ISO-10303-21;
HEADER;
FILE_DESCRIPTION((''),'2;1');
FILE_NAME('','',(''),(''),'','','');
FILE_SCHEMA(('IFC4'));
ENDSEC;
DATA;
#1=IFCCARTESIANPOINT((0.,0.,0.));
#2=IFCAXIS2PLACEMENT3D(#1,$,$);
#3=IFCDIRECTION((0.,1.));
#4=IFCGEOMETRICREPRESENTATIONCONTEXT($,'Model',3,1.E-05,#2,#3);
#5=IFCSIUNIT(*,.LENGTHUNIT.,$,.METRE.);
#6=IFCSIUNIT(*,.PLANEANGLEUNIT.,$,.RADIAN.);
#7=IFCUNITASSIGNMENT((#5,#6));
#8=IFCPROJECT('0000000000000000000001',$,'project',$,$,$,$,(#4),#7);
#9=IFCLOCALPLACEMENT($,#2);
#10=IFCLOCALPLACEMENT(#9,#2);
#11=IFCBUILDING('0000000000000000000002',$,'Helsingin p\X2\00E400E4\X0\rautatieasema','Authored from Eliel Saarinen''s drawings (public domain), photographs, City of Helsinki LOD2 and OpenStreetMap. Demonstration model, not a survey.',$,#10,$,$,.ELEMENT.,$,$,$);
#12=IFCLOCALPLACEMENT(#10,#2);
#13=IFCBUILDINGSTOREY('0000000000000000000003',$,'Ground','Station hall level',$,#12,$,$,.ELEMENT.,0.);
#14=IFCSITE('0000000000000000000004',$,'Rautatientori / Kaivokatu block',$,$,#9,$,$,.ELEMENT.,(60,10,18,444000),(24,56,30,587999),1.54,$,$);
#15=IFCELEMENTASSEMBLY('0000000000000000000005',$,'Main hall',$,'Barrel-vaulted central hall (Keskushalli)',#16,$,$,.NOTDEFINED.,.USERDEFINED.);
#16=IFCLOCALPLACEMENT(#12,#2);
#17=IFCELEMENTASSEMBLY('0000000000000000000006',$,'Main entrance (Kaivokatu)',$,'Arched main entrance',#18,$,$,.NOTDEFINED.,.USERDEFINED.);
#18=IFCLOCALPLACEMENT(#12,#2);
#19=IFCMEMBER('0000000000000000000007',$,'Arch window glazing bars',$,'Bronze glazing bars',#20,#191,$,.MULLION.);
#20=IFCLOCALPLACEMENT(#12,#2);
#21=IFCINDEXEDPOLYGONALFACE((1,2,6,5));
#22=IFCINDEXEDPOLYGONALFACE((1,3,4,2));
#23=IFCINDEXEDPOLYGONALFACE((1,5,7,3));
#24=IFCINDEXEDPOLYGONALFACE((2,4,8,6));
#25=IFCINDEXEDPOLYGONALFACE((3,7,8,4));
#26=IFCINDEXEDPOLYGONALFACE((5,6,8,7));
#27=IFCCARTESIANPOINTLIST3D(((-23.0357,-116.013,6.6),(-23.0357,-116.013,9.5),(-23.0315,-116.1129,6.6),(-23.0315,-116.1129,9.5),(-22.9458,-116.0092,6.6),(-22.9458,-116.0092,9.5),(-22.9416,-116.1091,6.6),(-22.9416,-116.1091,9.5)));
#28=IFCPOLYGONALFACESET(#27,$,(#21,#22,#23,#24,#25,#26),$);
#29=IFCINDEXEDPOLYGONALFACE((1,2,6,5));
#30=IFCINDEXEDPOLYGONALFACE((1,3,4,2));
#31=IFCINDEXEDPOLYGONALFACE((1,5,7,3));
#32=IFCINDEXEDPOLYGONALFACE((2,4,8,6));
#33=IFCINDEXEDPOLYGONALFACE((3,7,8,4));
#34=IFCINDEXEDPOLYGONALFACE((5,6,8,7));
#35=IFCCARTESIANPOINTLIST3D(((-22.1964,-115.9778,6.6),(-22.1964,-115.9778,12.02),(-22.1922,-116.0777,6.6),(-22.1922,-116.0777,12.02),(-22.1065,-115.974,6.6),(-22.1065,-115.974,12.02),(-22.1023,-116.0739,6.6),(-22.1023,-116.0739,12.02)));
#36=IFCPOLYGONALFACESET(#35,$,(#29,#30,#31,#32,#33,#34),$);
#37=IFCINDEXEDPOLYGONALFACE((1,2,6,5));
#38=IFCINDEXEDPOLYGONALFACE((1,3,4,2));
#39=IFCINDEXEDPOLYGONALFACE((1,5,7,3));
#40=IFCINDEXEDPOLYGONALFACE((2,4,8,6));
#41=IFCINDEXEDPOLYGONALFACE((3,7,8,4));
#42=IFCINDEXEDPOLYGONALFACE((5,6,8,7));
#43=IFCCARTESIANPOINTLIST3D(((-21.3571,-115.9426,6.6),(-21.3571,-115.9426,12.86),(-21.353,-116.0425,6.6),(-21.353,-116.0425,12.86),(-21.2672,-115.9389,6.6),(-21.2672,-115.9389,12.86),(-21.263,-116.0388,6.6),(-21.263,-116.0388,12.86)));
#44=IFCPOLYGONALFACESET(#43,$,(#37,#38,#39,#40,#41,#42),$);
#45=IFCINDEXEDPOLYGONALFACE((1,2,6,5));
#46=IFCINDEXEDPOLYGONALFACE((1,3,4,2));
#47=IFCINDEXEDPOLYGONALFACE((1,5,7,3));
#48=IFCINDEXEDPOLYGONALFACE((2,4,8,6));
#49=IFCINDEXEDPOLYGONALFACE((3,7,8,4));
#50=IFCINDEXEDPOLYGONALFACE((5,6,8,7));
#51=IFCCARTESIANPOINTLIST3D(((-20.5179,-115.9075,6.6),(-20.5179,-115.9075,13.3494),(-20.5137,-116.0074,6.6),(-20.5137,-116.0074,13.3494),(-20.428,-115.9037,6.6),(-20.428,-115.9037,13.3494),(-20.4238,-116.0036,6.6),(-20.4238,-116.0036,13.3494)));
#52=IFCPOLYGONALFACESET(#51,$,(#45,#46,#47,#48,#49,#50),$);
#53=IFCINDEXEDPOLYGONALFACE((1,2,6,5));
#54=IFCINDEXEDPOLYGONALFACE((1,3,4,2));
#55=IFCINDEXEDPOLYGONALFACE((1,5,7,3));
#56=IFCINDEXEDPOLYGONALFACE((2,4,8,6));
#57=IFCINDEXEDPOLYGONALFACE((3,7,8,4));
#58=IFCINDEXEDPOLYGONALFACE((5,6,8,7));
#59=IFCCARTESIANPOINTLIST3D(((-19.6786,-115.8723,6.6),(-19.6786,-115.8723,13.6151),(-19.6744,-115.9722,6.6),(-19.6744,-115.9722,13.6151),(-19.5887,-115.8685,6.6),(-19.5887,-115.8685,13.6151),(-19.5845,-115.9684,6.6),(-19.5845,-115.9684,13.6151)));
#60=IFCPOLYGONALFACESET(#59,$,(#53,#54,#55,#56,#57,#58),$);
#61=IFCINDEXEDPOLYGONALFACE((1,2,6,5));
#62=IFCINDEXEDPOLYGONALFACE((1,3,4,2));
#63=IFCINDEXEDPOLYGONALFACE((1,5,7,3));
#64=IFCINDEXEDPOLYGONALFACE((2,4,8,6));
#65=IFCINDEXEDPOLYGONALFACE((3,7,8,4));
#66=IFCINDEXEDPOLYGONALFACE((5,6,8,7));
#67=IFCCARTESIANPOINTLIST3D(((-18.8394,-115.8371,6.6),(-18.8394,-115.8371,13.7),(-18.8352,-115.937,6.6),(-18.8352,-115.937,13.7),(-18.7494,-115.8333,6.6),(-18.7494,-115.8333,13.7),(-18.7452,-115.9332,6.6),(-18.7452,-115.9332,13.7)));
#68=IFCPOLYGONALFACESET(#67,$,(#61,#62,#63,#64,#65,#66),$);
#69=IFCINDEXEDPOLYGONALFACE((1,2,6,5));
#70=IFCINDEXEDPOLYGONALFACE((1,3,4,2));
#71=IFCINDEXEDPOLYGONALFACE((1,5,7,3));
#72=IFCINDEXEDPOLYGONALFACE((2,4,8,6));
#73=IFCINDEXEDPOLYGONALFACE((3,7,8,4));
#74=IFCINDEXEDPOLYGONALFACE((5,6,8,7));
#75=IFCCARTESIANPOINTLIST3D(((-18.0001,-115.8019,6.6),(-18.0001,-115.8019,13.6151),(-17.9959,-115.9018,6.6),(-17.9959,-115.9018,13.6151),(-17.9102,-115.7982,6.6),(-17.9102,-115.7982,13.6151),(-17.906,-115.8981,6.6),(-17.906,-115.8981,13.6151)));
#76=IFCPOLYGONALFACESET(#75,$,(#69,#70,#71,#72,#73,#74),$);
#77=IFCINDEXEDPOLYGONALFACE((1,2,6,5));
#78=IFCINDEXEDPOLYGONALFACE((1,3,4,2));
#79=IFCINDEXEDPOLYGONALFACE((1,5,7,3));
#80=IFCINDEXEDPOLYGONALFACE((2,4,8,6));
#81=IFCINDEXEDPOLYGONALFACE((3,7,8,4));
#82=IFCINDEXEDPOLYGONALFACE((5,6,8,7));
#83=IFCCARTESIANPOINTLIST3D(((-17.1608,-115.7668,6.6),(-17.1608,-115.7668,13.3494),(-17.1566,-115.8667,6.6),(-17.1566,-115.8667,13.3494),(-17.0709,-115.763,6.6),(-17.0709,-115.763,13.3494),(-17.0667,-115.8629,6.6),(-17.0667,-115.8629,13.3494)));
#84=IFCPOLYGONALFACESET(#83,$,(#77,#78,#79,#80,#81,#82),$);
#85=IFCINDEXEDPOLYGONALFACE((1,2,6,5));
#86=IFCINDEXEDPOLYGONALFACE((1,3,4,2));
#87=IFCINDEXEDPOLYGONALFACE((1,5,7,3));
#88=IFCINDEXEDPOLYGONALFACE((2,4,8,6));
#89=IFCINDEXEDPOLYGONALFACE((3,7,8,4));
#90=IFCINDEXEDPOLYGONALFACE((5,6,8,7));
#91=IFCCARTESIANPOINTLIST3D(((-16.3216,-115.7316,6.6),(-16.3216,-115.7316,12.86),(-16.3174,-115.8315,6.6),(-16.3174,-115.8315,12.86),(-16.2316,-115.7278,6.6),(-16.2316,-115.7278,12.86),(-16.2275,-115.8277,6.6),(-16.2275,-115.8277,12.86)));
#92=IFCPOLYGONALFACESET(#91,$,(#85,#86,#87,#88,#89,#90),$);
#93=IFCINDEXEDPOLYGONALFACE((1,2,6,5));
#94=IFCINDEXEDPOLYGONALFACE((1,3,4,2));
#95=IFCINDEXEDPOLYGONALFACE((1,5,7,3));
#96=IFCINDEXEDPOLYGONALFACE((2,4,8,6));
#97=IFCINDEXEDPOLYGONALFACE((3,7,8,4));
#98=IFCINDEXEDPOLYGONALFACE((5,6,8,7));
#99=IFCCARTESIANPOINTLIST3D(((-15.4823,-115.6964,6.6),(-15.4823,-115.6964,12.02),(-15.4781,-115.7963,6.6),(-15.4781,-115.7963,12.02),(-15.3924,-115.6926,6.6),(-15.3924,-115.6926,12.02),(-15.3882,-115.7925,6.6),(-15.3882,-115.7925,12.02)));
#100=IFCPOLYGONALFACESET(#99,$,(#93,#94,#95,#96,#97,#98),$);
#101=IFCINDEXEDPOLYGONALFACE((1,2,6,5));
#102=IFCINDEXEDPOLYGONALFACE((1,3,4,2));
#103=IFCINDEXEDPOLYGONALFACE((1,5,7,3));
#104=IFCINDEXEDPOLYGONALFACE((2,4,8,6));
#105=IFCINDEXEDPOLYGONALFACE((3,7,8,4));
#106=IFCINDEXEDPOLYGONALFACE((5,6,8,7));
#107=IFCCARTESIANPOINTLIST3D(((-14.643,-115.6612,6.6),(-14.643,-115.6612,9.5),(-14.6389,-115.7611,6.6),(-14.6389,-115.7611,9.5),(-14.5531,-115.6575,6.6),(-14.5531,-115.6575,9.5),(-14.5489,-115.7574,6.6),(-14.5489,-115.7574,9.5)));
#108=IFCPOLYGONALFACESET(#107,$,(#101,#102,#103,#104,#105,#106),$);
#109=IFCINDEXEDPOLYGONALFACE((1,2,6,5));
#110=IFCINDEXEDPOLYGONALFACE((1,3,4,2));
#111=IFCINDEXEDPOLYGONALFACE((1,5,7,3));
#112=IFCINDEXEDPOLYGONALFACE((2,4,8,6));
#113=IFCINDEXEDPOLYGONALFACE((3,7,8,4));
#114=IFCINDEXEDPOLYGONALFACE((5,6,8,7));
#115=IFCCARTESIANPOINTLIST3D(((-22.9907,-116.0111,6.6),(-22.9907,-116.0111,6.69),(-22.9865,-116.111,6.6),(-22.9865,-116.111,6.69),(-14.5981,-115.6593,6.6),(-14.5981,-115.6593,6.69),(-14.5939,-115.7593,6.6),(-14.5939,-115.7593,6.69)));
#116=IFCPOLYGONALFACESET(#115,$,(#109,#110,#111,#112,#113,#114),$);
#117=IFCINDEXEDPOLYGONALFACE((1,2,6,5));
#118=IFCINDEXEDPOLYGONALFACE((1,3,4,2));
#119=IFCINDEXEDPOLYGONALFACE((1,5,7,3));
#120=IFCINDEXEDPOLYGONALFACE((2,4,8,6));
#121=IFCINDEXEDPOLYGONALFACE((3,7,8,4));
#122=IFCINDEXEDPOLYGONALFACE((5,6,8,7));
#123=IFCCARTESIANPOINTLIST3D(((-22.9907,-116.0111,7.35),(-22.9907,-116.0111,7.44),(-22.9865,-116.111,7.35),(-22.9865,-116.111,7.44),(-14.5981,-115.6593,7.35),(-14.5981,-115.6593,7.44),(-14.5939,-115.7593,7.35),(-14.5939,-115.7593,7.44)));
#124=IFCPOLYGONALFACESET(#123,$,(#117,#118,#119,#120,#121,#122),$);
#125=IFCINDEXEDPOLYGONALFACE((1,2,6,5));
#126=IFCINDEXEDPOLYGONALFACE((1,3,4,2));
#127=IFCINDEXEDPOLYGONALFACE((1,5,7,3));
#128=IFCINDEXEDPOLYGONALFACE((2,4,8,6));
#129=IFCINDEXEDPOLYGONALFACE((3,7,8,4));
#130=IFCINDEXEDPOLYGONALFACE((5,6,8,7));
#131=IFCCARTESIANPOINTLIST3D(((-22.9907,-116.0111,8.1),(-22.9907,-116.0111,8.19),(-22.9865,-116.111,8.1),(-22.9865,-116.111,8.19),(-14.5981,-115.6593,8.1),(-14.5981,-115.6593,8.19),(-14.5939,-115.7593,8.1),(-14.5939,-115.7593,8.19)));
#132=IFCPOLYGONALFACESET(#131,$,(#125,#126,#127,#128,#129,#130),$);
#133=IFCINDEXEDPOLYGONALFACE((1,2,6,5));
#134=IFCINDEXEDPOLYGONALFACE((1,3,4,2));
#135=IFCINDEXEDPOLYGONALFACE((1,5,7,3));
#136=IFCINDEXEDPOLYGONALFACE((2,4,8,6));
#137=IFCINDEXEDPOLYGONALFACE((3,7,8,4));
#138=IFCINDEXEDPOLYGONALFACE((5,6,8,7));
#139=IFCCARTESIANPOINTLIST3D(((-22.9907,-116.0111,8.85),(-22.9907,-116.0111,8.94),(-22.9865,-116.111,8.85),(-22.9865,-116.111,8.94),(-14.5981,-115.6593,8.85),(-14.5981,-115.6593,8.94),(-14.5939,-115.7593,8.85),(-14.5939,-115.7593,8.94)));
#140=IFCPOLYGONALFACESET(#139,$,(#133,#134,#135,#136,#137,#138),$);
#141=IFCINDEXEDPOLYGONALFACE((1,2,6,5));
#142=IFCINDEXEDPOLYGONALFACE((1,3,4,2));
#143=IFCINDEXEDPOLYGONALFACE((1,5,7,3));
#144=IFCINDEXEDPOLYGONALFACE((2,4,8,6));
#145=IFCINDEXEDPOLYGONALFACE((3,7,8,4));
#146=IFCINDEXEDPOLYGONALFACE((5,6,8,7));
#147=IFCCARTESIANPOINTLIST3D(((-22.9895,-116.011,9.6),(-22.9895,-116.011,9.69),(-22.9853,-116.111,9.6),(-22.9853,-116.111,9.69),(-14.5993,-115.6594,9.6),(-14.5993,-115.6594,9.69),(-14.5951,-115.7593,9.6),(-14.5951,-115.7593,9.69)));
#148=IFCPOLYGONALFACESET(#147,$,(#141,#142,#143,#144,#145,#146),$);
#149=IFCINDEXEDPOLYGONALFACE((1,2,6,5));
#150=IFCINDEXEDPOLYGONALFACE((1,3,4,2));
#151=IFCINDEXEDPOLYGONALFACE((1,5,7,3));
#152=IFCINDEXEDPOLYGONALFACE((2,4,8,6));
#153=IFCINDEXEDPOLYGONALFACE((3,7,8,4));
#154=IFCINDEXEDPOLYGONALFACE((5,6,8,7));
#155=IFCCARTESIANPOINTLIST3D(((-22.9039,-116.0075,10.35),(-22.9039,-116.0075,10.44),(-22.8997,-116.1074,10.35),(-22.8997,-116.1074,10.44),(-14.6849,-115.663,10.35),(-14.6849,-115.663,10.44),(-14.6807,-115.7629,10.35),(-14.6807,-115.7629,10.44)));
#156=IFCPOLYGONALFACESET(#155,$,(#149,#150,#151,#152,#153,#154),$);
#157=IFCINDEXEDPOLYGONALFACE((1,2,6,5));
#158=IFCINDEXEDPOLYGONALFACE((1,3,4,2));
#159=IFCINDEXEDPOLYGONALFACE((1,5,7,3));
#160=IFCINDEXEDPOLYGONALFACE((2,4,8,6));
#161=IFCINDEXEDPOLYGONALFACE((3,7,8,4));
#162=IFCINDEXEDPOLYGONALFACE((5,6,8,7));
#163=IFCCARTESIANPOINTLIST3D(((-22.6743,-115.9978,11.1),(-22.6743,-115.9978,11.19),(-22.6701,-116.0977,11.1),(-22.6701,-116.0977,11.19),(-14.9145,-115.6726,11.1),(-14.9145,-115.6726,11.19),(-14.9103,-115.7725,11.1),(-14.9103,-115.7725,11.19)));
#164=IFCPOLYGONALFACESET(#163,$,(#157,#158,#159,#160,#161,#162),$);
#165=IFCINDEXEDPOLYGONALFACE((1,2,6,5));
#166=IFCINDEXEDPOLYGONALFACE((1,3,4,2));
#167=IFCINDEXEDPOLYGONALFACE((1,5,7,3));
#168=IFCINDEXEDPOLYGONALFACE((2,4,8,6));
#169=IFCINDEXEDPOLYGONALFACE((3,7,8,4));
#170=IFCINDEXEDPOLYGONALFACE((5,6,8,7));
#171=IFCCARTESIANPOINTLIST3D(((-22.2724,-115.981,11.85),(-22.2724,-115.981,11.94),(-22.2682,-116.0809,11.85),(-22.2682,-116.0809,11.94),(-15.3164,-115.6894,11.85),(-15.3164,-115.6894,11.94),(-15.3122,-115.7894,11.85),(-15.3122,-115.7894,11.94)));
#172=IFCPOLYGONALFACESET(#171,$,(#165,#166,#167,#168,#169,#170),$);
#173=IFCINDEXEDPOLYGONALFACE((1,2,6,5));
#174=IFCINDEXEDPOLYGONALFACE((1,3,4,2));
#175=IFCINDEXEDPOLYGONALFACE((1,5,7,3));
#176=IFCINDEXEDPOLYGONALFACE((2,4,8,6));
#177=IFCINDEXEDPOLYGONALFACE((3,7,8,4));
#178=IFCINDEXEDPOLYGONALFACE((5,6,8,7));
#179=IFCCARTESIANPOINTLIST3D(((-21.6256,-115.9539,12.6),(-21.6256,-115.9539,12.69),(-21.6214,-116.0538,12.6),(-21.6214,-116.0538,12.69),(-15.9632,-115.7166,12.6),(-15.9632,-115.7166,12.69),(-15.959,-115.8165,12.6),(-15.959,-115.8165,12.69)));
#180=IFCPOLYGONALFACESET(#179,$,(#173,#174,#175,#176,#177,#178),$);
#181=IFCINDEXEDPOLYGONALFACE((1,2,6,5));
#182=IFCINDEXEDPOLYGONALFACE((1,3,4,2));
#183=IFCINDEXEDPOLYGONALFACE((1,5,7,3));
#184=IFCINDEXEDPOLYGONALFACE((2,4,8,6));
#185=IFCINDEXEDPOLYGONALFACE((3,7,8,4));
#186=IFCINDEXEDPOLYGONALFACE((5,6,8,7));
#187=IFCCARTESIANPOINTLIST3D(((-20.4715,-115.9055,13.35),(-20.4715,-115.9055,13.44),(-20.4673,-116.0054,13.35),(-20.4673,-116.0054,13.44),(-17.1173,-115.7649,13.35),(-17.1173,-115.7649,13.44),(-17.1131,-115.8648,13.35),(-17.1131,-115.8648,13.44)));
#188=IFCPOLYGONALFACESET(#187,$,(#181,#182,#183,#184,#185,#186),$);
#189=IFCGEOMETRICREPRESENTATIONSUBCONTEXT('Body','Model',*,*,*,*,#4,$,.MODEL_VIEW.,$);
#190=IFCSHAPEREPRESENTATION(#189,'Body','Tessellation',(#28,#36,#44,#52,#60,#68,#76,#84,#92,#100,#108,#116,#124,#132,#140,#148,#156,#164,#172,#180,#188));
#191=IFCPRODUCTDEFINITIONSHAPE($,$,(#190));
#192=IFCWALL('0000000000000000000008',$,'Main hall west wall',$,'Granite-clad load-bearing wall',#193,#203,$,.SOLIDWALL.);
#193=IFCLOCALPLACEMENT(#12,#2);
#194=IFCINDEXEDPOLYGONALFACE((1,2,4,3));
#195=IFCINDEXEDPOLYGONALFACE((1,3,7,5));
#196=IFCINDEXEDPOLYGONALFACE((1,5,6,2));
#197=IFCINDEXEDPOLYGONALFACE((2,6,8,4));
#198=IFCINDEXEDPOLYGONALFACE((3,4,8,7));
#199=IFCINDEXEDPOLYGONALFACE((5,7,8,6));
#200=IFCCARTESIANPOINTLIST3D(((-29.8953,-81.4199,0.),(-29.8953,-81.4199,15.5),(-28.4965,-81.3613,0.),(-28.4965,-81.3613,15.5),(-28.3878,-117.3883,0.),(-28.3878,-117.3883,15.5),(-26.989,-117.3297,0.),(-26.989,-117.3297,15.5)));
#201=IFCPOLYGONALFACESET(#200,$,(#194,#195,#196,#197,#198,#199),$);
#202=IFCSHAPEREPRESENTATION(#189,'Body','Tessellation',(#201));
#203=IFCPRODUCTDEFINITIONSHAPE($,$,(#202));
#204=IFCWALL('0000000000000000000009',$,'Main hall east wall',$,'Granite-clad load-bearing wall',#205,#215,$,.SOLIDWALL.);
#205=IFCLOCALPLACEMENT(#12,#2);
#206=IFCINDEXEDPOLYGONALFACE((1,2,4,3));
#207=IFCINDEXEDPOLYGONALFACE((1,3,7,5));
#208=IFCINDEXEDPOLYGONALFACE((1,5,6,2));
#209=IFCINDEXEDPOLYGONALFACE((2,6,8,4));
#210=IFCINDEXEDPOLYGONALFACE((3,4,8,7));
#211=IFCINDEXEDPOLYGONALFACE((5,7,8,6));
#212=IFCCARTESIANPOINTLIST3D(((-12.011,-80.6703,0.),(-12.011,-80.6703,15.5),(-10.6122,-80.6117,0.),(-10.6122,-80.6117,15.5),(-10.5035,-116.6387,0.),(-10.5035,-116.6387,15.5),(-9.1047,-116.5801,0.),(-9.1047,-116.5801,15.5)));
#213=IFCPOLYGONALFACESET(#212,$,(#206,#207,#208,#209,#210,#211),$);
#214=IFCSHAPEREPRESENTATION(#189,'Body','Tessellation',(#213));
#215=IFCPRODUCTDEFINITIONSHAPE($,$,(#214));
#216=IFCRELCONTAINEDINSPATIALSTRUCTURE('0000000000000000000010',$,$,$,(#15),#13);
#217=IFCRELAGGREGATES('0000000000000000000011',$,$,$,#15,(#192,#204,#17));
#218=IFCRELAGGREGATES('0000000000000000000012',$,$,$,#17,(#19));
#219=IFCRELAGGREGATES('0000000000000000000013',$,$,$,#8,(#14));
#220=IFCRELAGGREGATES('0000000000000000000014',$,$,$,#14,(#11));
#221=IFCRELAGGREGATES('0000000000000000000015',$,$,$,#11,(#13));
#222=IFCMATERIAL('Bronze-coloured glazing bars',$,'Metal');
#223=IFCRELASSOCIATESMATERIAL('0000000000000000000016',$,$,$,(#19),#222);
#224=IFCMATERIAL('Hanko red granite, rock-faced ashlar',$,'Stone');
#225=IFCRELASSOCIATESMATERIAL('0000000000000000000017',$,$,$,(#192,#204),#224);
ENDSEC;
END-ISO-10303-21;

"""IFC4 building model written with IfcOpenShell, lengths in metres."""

from ifc_helpers import new_model, si_unit, direction, frame, frame_2d, origin, place, context, subcontext, project, spatial, rectangle, extrude, material, element, aggregate, save


model = new_model("IFC4")

# Units and contexts
model_context = context("Model", 3, precision=1e-05, world=origin(), true_north=direction((0.0, 1.0)))
body_context = subcontext(model_context, "Body", "Model", "MODEL_VIEW")
ifc_project = project(units=[si_unit("LENGTHUNIT", "METRE"), si_unit("PLANEANGLEUNIT", "RADIAN")], contexts=[model_context])

# Site, building, storey
site_placement = place(None, origin())
site = spatial("IfcSite", under=ifc_project, at=site_placement, Name="Rautatientori / Kaivokatu block", CompositionType="ELEMENT", RefLatitude=(60, 10, 18, 444000), RefLongitude=(24, 56, 30, 587999), RefElevation=1.54)
building_placement = place(site_placement, origin())
building = spatial("IfcBuilding", under=site, at=building_placement, Name="Helsingin päärautatieasema", Description="Authored from Eliel Saarinen's drawings (public domain), photographs, City of Helsinki LOD2 and OpenStreetMap. Demonstration model, not a survey.", CompositionType="ELEMENT")
storey_placement = place(building_placement, origin())
storey = spatial("IfcBuildingStorey", under=building, at=storey_placement, Name="Ground", Description="Station hall level", CompositionType="ELEMENT", Elevation=0.0)

# Element assemblies, member, walls
assembly_1_placement = place(building_placement, origin())
assembly_1 = element("IfcElementAssembly", 1, at=assembly_1_placement, inside=storey, Name="Main hall", ObjectType="Barrel-vaulted central hall (Keskushalli)", AssemblyPlace="NOTDEFINED", PredefinedType="USERDEFINED")
assembly_2_placement = place(building_placement, origin())
assembly_2 = element("IfcElementAssembly", 2, at=assembly_2_placement, Name="Main entrance (Kaivokatu)", ObjectType="Arched main entrance", AssemblyPlace="NOTDEFINED", PredefinedType="USERDEFINED")
ifc_material_1 = material(Name="Bronze-coloured glazing bars", Category="Metal")
member_1_placement = place(building_placement, origin())
member_1 = element("IfcMember", 3, at=member_1_placement, material=ifc_material_1, Name="Arch window glazing bars", ObjectType="Bronze glazing bars", PredefinedType="MULLION", context=body_context, shape_type="SweptSolid", body=[
    extrude(rectangle(XDim=0.09, YDim=0.1, at=frame_2d((0.0, 0.0), x_axis=(0.999123, 0.041876))), frame((-22.9886, -116.0611, 6.6)), (0.0, 0.0, 1.0), 2.9),
    extrude(rectangle(XDim=0.09, YDim=0.1, at=frame_2d((0.0, 0.0), x_axis=(0.999123, 0.041876))), frame((-22.1494, -116.0259, 6.6)), (0.0, 0.0, 1.0), 5.42),
    extrude(rectangle(XDim=0.09, YDim=0.1, at=frame_2d((0.0, 0.0), x_axis=(0.999123, 0.041876))), frame((-21.3101, -115.9907, 6.6)), (0.0, 0.0, 1.0), 6.26),
    extrude(rectangle(XDim=0.09, YDim=0.1, at=frame_2d((0.0, 0.0), x_axis=(0.999123, 0.041876))), frame((-20.4708, -115.9555, 6.6)), (0.0, 0.0, 1.0), 6.7494),
    extrude(rectangle(XDim=0.09, YDim=0.1, at=frame_2d((0.0, 0.0), x_axis=(0.999123, 0.041876))), frame((-19.6316, -115.9204, 6.6)), (0.0, 0.0, 1.0), 7.0151),
    extrude(rectangle(XDim=0.09, YDim=0.1, at=frame_2d((0.0, 0.0), x_axis=(0.999123, 0.041876))), frame((-18.7923, -115.8852, 6.6)), (0.0, 0.0, 1.0), 7.1),
    extrude(rectangle(XDim=0.09, YDim=0.1, at=frame_2d((0.0, 0.0), x_axis=(0.999123, 0.041876))), frame((-17.953, -115.85, 6.6)), (0.0, 0.0, 1.0), 7.0151),
    extrude(rectangle(XDim=0.09, YDim=0.1, at=frame_2d((0.0, 0.0), x_axis=(0.999123, 0.041876))), frame((-17.1138, -115.8148, 6.6)), (0.0, 0.0, 1.0), 6.7494),
    extrude(rectangle(XDim=0.09, YDim=0.1, at=frame_2d((0.0, 0.0), x_axis=(0.999123, 0.041876))), frame((-16.2745, -115.7796, 6.6)), (0.0, 0.0, 1.0), 6.26),
    extrude(rectangle(XDim=0.09, YDim=0.1, at=frame_2d((0.0, 0.0), x_axis=(0.999123, 0.041876))), frame((-15.4352, -115.7445, 6.6)), (0.0, 0.0, 1.0), 5.42),
    extrude(rectangle(XDim=0.09, YDim=0.1, at=frame_2d((0.0, 0.0), x_axis=(0.999123, 0.041876))), frame((-14.596, -115.7093, 6.6)), (0.0, 0.0, 1.0), 2.9),
    extrude(rectangle(XDim=8.4, YDim=0.1, at=frame_2d((0.0, 0.0), x_axis=(0.999123, 0.041876))), frame((-18.7923, -115.8852, 6.6)), (0.0, 0.0, 1.0), 0.09),
    extrude(rectangle(XDim=8.4, YDim=0.1, at=frame_2d((0.0, 0.0), x_axis=(0.999123, 0.041876))), frame((-18.7923, -115.8852, 7.35)), (0.0, 0.0, 1.0), 0.09),
    extrude(rectangle(XDim=8.4, YDim=0.1, at=frame_2d((0.0, 0.0), x_axis=(0.999123, 0.041876))), frame((-18.7923, -115.8852, 8.1)), (0.0, 0.0, 1.0), 0.09),
    extrude(rectangle(XDim=8.4, YDim=0.1, at=frame_2d((0.0, 0.0), x_axis=(0.999123, 0.041876))), frame((-18.7923, -115.8852, 8.85)), (0.0, 0.0, 1.0), 0.09),
    extrude(rectangle(XDim=8.3976, YDim=0.1, at=frame_2d((0.0, 0.0), x_axis=(0.999123, 0.041876))), frame((-18.7923, -115.8852, 9.6)), (0.0, 0.0, 1.0), 0.09),
    extrude(rectangle(XDim=8.2262, YDim=0.1, at=frame_2d((0.0, 0.0), x_axis=(0.999123, 0.041876))), frame((-18.7923, -115.8852, 10.35)), (0.0, 0.0, 1.0), 0.09),
    extrude(rectangle(XDim=7.7666, YDim=0.1, at=frame_2d((0.0, 0.0), x_axis=(0.999123, 0.041876))), frame((-18.7923, -115.8852, 11.1)), (0.0, 0.0, 1.0), 0.09),
    extrude(rectangle(XDim=6.962, YDim=0.1, at=frame_2d((0.0, 0.0), x_axis=(0.999123, 0.041876))), frame((-18.7923, -115.8852, 11.85)), (0.0, 0.0, 1.0), 0.09),
    extrude(rectangle(XDim=5.6675, YDim=0.1, at=frame_2d((0.0, 0.0), x_axis=(0.999123, 0.041876))), frame((-18.7923, -115.8852, 12.6)), (0.0, 0.0, 1.0), 0.09),
    extrude(rectangle(XDim=3.3571, YDim=0.1, at=frame_2d((0.0, 0.0), x_axis=(0.999123, 0.041876))), frame((-18.7923, -115.8852, 13.35)), (0.0, 0.0, 1.0), 0.09),
])
ifc_material_2 = material(Name="Hanko red granite, rock-faced ashlar", Category="Stone")
wall_1_placement = place(building_placement, origin())
wall_1 = element("IfcWall", 4, at=wall_1_placement, material=ifc_material_2, Name="Main hall west wall", ObjectType="Granite-clad load-bearing wall", PredefinedType="SOLIDWALL", context=body_context, shape_type="SweptSolid", body=[
    extrude(rectangle(XDim=1.4, YDim=36.0, at=frame_2d((0.0, 0.0), x_axis=(0.999123, 0.041876))), frame((-28.4421, -99.3748, 0.0)), (0.0, 0.0, 1.0), 15.5),
])
wall_2_placement = place(building_placement, origin())
wall_2 = element("IfcWall", 5, at=wall_2_placement, material=ifc_material_2, Name="Main hall east wall", ObjectType="Granite-clad load-bearing wall", PredefinedType="SOLIDWALL", context=body_context, shape_type="SweptSolid", body=[
    extrude(rectangle(XDim=1.4, YDim=36.0, at=frame_2d((0.0, 0.0), x_axis=(0.999123, 0.041876))), frame((-10.5579, -98.6252, 0.0)), (0.0, 0.0, 1.0), 15.5),
])
aggregate(assembly_1, [wall_1, wall_2, assembly_2])
aggregate(assembly_2, [member_1])

save(model, "model.ifc")
